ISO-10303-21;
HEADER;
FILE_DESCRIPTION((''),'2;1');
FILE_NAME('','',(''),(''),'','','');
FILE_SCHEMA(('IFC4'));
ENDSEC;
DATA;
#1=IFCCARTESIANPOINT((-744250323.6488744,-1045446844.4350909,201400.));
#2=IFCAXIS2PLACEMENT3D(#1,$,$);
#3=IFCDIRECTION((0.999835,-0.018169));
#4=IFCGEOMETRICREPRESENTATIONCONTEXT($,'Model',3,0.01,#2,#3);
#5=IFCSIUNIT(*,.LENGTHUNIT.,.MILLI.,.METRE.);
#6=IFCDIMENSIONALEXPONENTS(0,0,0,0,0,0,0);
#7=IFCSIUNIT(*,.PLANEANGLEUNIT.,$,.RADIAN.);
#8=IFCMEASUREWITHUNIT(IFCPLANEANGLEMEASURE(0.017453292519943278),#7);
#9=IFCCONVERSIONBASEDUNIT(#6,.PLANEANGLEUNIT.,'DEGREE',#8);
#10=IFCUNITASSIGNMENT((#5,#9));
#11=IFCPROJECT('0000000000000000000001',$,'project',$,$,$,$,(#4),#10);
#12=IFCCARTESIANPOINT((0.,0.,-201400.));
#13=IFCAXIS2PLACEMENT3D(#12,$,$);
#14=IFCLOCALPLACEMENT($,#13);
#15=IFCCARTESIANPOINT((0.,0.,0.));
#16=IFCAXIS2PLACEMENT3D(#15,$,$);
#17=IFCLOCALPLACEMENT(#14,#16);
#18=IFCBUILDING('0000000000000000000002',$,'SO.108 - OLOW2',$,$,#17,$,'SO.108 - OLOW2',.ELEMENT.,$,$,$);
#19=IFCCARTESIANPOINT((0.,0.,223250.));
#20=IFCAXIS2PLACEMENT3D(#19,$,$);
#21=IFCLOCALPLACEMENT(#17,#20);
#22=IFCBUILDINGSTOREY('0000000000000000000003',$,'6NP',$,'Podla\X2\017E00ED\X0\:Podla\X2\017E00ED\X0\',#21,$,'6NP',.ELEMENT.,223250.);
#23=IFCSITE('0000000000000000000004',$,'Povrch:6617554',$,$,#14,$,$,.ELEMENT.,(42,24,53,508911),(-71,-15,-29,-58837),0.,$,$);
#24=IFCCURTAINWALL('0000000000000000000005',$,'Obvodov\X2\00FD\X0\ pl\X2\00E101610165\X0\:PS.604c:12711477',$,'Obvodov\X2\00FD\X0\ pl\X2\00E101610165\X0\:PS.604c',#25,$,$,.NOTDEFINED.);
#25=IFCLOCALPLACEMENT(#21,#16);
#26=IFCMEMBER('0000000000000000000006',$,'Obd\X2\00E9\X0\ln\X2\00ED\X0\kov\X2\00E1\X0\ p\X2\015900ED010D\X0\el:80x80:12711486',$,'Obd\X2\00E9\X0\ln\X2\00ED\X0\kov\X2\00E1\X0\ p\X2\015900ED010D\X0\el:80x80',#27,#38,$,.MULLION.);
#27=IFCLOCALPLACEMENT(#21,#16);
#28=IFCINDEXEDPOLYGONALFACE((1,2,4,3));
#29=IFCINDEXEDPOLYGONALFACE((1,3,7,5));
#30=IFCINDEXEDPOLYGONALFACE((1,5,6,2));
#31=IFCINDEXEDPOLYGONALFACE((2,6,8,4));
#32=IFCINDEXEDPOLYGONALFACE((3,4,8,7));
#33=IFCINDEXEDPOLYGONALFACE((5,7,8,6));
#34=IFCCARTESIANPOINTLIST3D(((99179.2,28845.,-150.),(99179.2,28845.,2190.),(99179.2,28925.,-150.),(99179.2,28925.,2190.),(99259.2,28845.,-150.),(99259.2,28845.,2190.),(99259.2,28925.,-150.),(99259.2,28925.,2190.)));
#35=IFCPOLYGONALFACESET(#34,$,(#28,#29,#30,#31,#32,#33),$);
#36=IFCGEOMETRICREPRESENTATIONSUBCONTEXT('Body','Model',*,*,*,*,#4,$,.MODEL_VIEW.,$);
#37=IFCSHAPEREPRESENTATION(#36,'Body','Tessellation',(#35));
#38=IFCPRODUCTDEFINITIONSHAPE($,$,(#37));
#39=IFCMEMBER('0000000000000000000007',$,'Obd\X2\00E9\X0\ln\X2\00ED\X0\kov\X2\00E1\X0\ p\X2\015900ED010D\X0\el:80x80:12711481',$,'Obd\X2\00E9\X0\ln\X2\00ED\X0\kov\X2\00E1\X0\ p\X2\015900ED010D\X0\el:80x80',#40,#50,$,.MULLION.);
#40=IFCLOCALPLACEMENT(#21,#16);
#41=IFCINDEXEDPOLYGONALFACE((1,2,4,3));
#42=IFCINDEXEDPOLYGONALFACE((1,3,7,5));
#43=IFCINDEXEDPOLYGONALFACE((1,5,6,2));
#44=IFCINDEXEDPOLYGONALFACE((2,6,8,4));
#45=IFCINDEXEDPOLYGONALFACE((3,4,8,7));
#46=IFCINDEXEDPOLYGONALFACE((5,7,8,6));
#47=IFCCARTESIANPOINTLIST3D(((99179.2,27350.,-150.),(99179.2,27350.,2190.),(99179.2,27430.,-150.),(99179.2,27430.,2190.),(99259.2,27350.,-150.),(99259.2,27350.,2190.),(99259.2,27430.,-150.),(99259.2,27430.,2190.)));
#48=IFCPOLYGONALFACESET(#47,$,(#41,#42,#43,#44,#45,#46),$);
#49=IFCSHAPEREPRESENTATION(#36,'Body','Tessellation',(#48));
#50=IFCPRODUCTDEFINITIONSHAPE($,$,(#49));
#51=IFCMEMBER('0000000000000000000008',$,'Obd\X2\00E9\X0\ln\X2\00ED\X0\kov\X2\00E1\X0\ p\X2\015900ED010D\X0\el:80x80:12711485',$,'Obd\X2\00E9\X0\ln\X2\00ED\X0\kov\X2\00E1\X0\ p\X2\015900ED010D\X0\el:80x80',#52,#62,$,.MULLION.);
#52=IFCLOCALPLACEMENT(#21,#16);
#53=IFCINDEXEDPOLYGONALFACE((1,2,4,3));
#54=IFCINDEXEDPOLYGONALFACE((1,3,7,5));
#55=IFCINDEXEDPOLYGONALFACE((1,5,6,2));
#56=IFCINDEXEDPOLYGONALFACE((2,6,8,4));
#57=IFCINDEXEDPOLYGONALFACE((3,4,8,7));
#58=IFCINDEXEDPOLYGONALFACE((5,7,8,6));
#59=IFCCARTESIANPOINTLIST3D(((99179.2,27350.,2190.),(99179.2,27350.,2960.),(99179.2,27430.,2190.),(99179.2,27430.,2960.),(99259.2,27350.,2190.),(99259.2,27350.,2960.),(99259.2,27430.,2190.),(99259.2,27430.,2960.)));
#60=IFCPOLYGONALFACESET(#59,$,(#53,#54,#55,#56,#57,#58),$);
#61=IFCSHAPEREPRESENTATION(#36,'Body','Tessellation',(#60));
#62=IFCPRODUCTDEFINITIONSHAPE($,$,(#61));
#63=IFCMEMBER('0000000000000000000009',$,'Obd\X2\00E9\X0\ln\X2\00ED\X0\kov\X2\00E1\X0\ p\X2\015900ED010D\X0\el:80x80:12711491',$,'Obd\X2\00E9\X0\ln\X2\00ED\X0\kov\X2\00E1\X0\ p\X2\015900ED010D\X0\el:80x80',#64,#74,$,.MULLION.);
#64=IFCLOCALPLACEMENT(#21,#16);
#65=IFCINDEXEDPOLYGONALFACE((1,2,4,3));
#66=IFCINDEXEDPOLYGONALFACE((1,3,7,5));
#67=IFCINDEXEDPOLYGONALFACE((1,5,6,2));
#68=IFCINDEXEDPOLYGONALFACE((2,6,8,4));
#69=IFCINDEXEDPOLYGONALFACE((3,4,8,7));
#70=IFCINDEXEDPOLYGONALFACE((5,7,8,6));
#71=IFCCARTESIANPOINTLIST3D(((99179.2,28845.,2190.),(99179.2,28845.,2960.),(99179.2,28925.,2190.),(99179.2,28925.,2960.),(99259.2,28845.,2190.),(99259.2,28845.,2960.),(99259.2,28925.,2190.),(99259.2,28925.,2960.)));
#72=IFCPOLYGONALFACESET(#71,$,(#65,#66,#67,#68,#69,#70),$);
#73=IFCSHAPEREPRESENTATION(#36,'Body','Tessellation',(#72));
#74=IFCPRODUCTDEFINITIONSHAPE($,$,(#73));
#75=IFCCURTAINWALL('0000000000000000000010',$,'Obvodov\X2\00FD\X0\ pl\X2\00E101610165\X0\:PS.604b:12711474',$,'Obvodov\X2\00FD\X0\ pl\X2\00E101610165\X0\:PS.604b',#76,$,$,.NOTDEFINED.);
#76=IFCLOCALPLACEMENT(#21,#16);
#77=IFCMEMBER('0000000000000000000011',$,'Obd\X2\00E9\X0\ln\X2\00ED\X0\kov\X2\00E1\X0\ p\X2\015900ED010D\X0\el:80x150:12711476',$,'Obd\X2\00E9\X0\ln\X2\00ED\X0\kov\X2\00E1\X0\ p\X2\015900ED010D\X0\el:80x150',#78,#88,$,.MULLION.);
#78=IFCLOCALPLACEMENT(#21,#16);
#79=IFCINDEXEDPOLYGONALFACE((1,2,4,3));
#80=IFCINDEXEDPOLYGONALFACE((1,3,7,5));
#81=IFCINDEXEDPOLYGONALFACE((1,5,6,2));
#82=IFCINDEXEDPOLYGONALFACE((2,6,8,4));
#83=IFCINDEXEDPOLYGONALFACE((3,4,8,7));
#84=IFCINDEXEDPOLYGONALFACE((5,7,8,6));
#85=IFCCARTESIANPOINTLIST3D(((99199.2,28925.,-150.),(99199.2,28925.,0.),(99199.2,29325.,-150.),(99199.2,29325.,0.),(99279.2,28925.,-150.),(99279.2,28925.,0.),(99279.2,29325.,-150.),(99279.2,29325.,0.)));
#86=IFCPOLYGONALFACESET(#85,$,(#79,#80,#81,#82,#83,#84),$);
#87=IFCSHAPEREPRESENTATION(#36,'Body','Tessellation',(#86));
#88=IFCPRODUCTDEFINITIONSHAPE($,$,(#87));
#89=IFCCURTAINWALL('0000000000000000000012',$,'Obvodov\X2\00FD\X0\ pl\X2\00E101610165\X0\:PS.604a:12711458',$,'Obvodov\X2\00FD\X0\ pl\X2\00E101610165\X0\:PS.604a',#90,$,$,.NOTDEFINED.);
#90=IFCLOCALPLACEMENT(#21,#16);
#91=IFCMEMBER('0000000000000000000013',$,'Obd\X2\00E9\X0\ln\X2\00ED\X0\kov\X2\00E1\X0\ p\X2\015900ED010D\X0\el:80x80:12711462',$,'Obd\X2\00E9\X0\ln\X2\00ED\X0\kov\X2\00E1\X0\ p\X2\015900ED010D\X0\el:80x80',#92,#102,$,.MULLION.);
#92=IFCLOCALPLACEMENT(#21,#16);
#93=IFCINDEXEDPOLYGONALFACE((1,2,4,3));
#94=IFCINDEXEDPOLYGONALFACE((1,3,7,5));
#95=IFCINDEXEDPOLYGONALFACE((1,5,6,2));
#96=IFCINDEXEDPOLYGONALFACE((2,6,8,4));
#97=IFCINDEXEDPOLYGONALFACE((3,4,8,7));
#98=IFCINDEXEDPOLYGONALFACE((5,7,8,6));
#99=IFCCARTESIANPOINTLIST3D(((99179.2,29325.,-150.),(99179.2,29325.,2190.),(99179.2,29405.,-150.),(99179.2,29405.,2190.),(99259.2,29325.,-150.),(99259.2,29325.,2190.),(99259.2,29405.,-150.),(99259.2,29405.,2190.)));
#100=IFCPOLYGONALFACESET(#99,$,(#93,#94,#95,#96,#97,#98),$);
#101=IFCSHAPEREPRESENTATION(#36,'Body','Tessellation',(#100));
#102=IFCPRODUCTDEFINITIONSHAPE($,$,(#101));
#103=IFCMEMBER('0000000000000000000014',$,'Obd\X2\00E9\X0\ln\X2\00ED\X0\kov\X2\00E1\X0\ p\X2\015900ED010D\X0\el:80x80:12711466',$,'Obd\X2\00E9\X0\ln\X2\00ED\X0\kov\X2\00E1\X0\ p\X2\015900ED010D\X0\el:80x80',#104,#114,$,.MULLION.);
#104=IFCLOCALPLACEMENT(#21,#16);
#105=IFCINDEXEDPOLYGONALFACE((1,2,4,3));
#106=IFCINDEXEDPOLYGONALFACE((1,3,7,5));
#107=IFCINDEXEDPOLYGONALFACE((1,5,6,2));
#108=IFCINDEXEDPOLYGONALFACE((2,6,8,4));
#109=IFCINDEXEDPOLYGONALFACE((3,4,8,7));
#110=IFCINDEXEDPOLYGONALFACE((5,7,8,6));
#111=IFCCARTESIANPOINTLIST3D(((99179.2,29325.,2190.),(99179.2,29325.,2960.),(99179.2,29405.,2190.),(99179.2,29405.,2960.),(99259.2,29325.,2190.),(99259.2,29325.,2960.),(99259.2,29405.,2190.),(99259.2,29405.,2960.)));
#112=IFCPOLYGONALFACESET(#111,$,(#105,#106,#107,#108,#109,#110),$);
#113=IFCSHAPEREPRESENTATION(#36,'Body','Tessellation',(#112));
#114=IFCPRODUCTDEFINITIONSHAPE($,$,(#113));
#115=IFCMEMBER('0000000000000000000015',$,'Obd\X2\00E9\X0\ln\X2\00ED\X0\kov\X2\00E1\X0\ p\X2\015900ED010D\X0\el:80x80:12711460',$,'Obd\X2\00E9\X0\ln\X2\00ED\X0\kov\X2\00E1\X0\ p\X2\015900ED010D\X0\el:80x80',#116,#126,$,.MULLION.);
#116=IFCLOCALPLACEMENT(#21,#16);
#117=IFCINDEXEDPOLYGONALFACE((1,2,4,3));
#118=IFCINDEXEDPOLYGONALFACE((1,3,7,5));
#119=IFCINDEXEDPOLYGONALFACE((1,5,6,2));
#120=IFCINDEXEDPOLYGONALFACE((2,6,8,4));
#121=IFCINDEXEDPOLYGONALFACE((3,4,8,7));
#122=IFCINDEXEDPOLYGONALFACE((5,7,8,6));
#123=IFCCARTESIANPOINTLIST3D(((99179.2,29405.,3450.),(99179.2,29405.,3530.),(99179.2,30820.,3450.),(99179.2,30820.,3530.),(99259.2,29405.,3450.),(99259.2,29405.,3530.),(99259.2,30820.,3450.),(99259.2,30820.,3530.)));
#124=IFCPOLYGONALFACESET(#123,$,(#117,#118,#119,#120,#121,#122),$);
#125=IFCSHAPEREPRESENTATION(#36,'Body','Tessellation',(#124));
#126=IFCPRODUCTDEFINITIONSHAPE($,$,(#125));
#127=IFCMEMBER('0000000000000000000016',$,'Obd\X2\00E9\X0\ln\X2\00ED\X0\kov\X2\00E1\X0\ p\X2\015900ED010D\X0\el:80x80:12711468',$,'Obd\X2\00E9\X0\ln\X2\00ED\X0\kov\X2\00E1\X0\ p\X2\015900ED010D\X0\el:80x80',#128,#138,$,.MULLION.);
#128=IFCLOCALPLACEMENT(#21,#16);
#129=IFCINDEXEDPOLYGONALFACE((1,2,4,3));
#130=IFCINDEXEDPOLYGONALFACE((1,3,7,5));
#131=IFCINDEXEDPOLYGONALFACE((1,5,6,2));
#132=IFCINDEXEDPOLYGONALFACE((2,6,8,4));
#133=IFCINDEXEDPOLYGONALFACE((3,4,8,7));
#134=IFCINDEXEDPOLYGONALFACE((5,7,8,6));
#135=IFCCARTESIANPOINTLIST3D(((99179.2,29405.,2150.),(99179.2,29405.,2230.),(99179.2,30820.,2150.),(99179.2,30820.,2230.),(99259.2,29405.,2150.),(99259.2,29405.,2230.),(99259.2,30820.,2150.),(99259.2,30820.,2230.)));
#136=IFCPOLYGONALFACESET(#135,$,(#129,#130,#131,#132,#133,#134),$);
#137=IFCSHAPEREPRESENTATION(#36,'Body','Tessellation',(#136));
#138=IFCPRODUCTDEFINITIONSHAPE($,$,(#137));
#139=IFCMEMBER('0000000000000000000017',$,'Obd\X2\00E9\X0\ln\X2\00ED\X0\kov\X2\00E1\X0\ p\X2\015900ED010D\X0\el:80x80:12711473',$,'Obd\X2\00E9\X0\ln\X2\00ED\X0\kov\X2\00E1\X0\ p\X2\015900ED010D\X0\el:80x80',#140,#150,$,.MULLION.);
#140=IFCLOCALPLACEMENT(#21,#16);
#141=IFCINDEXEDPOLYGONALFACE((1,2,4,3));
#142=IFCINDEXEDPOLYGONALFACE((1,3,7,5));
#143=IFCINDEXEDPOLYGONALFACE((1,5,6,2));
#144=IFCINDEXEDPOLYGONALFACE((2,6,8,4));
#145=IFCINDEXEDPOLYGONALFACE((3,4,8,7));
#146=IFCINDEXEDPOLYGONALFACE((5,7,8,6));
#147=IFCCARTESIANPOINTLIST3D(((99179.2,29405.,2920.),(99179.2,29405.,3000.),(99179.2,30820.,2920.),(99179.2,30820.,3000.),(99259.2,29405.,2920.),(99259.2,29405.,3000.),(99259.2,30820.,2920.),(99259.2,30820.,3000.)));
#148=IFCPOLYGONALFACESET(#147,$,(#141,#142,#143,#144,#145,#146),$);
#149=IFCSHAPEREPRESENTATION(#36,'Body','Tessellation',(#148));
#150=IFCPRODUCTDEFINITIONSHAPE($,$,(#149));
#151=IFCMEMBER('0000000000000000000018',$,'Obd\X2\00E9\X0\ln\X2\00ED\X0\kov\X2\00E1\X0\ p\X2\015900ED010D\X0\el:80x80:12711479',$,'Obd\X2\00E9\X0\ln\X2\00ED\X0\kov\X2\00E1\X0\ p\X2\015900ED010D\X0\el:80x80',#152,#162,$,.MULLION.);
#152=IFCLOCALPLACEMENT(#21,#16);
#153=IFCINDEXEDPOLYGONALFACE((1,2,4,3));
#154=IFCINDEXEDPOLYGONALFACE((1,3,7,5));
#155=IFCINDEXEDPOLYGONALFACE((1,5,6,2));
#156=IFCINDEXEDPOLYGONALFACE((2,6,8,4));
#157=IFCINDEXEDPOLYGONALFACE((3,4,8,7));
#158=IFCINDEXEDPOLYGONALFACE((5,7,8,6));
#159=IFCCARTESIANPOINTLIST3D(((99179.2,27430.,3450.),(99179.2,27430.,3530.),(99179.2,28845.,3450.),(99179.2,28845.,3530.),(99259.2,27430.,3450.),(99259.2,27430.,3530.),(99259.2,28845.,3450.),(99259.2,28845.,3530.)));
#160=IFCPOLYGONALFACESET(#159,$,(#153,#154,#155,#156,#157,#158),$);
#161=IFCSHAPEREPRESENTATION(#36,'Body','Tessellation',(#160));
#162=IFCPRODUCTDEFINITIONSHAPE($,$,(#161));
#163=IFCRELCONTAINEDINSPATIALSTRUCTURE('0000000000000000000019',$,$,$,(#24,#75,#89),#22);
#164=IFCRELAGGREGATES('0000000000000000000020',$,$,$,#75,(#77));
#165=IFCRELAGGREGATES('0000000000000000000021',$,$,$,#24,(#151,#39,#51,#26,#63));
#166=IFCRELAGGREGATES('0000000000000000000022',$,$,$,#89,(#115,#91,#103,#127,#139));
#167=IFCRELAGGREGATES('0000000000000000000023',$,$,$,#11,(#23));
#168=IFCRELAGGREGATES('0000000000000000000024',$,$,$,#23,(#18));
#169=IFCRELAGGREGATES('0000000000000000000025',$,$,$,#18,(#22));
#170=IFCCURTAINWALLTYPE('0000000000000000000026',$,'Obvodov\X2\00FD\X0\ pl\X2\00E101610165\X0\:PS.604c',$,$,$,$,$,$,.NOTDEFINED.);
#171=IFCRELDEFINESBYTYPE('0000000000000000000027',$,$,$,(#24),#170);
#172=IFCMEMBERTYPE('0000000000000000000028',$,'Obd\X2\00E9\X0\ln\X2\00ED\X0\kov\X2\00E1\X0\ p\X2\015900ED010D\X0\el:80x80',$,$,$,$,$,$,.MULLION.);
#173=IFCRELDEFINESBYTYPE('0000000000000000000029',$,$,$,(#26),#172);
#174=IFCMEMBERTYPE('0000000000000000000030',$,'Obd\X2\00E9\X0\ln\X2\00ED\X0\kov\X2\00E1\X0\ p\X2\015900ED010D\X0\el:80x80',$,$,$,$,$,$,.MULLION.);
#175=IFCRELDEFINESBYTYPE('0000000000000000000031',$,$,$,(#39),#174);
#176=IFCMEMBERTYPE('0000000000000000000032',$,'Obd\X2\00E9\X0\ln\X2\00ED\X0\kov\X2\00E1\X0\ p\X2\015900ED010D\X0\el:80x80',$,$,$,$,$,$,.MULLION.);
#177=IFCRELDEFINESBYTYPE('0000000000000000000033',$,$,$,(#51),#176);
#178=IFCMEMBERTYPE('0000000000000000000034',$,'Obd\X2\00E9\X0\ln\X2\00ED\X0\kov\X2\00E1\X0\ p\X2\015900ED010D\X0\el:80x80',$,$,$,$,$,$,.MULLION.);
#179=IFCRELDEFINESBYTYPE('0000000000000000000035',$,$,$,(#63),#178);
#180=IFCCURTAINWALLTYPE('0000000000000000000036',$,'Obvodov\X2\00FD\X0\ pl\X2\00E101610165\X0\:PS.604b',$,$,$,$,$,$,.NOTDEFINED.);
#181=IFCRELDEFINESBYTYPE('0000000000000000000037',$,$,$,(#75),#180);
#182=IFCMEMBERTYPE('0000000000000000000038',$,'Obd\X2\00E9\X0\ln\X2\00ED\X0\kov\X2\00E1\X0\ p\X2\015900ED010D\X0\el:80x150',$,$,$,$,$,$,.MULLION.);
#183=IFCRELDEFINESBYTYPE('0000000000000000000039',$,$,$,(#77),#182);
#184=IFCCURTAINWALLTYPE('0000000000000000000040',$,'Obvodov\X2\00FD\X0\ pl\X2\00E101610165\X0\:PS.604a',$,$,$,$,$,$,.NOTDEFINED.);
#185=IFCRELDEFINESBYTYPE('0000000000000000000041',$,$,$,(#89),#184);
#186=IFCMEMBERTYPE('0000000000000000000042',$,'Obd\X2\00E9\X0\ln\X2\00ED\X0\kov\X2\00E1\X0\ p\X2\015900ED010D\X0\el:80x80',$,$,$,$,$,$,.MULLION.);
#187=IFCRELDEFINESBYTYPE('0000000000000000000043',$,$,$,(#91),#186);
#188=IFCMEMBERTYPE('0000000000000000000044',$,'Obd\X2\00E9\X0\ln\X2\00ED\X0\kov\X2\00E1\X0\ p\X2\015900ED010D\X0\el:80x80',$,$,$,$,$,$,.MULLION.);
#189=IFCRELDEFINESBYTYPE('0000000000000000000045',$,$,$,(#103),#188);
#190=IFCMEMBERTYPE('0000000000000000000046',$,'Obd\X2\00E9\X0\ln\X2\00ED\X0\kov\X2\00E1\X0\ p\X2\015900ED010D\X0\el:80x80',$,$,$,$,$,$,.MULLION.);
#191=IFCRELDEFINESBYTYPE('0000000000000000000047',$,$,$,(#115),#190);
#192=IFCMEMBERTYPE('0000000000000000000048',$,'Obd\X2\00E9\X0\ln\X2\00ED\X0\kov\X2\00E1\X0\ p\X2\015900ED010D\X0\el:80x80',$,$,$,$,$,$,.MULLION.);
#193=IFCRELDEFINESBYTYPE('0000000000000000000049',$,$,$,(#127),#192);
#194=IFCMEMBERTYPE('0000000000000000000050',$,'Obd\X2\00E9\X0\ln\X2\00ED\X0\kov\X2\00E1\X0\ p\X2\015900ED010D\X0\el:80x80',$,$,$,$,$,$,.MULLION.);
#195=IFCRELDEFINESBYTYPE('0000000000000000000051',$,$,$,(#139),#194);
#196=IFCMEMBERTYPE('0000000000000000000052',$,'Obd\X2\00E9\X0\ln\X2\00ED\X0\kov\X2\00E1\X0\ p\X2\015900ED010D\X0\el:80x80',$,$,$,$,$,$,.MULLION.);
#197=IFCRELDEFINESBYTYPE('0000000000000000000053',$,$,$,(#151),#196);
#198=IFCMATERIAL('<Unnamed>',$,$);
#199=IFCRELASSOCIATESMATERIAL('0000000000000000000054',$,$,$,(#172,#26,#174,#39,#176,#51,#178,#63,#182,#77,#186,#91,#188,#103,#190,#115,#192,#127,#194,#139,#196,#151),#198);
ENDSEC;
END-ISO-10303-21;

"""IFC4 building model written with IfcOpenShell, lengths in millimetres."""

from ifc_helpers import new_model, entity, si_unit, converted_unit, direction, frame, origin, place, context, subcontext, project, spatial, indexed_curve, outline, extrude, source, transform, mapped, material, type_object, type_shapes, element, aggregate, save


model = new_model("IFC4")

# Units and contexts
model_context = context("Model", 3, precision=0.01, world=frame((-744250323.6488744, -1045446844.4350909, 201400.0)), true_north=direction((0.999835, -0.018169)))
body_context = subcontext(model_context, "Body", "Model", "MODEL_VIEW")
ifc_project = project(units=[si_unit("LENGTHUNIT", "METRE", prefix="MILLI"), converted_unit("PLANEANGLEUNIT", "DEGREE", entity("IfcPlaneAngleMeasure", 0.017453292519943278), si_unit("PLANEANGLEUNIT", "RADIAN"), dimensions=[0, 0, 0, 0, 0, 0, 0])], contexts=[model_context])

# Site, building, storey
site_placement = place(None, frame((0.0, 0.0, -201400.0)))
site = spatial("IfcSite", under=ifc_project, at=site_placement, Name="Povrch:6617554", CompositionType="ELEMENT", RefLatitude=(42, 24, 53, 508911), RefLongitude=(-71, -15, -29, -58837), RefElevation=0.0)
building_placement = place(site_placement, origin())
building = spatial("IfcBuilding", under=site, at=building_placement, Name="SO.108 - OLOW2", LongName="SO.108 - OLOW2", CompositionType="ELEMENT")
storey_placement = place(building_placement, frame((0.0, 0.0, 223250.0)))
storey = spatial("IfcBuildingStorey", under=building, at=storey_placement, Name="6NP", ObjectType="Podlaží:Podlaží", LongName="6NP", CompositionType="ELEMENT", Elevation=223250.0)

# Curtain wall, members
curtain_wall_type_1 = type_object("IfcCurtainWallType", Name="Obvodový plášť:PS.604c", PredefinedType="NOTDEFINED")
curtain_wall_1_placement = place(storey_placement, frame((0.0, 0.0, -223250.0)))
curtain_wall_1 = element("IfcCurtainWall", 1, at=curtain_wall_1_placement, inside=storey, type_object=curtain_wall_type_1, Name="Obvodový plášť:PS.604c:12711477", ObjectType="Obvodový plášť:PS.604c", PredefinedType="NOTDEFINED")
ifc_material_1 = material(Name="<Unnamed>")
member_type_1 = type_object("IfcMemberType", Name="Obdélníková příčel:80x80", PredefinedType="MULLION", material=ifc_material_1)
shared_shape_1 = source(origin(), body_context, "Body", "SweptSolid", [
    extrude(outline(indexed_curve([(-40.0, -40.0), (40.0, -40.0), (40.0, 40.0), (-40.0, 40.0), (-40.0, -40.0)], self_intersect=False)), frame((-40.0, 0.0, -2340.0), z_axis=(0.0, 0.0, 1.0), x_axis=(-1.0, 0.0, 0.0)), (0.0, 0.0, 1.0), 2340.0),
])
type_shapes(member_type_1, [shared_shape_1])
member_1_placement = place(curtain_wall_1_placement, frame((99219.2, 28925.0, 225440.0), z_axis=(0.0, 0.0, 1.0), x_axis=(0.0, 1.0, 0.0)))
member_1 = element("IfcMember", 2, at=member_1_placement, type_object=member_type_1, material=ifc_material_1, Name="Obdélníková příčel:80x80:12711486", ObjectType="Obdélníková příčel:80x80", PredefinedType="MULLION", context=body_context, shape_type="MappedRepresentation", body=[
    mapped(shared_shape_1, transform((0.0, 0.0, 0.0), scale=1.0)),
])
member_type_2 = type_object("IfcMemberType", Name="Obdélníková příčel:80x80", PredefinedType="MULLION", material=ifc_material_1)
shared_shape_2 = source(origin(), body_context, "Body", "SweptSolid", [
    extrude(outline(indexed_curve([(-40.0, -40.0), (40.0, -40.0), (40.0, 40.0), (-40.0, 40.0), (-40.0, -40.0)], self_intersect=False)), frame((-40.0, 0.0, -2340.0), z_axis=(0.0, 0.0, 1.0), x_axis=(-1.0, 0.0, 0.0)), (0.0, 0.0, 1.0), 2340.0),
])
type_shapes(member_type_2, [shared_shape_2])
member_2_placement = place(curtain_wall_1_placement, frame((99219.2, 27350.0, 223100.0), z_axis=(0.0, 0.0, -1.0), x_axis=(0.0, -1.0, 0.0)))
member_2 = element("IfcMember", 3, at=member_2_placement, type_object=member_type_2, material=ifc_material_1, Name="Obdélníková příčel:80x80:12711481", ObjectType="Obdélníková příčel:80x80", PredefinedType="MULLION", context=body_context, shape_type="MappedRepresentation", body=[
    mapped(shared_shape_2, transform((0.0, 0.0, 0.0), scale=1.0)),
])
member_type_3 = type_object("IfcMemberType", Name="Obdélníková příčel:80x80", PredefinedType="MULLION", material=ifc_material_1)
shared_shape_3 = source(origin(), body_context, "Body", "SweptSolid", [
    extrude(outline(indexed_curve([(-40.0, -40.0), (40.0, -40.0), (40.0, 40.0), (-40.0, 40.0), (-40.0, -40.0)], self_intersect=False)), frame((-40.0, 0.0, -770.0), z_axis=(0.0, 0.0, 1.0), x_axis=(-1.0, 0.0, 0.0)), (0.0, 0.0, 1.0), 770.0),
])
type_shapes(member_type_3, [shared_shape_3])
member_3_placement = place(curtain_wall_1_placement, frame((99219.2, 27350.0, 225440.0), z_axis=(0.0, 0.0, -1.0), x_axis=(0.0, -1.0, 0.0)))
member_3 = element("IfcMember", 4, at=member_3_placement, type_object=member_type_3, material=ifc_material_1, Name="Obdélníková příčel:80x80:12711485", ObjectType="Obdélníková příčel:80x80", PredefinedType="MULLION", context=body_context, shape_type="MappedRepresentation", body=[
    mapped(shared_shape_3, transform((0.0, 0.0, 0.0), scale=1.0)),
])
member_type_4 = type_object("IfcMemberType", Name="Obdélníková příčel:80x80", PredefinedType="MULLION", material=ifc_material_1)
shared_shape_4 = source(origin(), body_context, "Body", "SweptSolid", [
    extrude(outline(indexed_curve([(-40.0, -40.0), (40.0, -40.0), (40.0, 40.0), (-40.0, 40.0), (-40.0, -40.0)], self_intersect=False)), frame((-40.0, 0.0, -770.0), z_axis=(0.0, 0.0, 1.0), x_axis=(-1.0, 0.0, 0.0)), (0.0, 0.0, 1.0), 770.0),
])
type_shapes(member_type_4, [shared_shape_4])
member_4_placement = place(curtain_wall_1_placement, frame((99219.2, 28925.0, 226210.0), z_axis=(0.0, 0.0, 1.0), x_axis=(0.0, 1.0, 0.0)))
member_4 = element("IfcMember", 5, at=member_4_placement, type_object=member_type_4, material=ifc_material_1, Name="Obdélníková příčel:80x80:12711491", ObjectType="Obdélníková příčel:80x80", PredefinedType="MULLION", context=body_context, shape_type="MappedRepresentation", body=[
    mapped(shared_shape_4, transform((0.0, 0.0, 0.0), scale=1.0)),
])

# Curtain wall, member
curtain_wall_type_2 = type_object("IfcCurtainWallType", Name="Obvodový plášť:PS.604b", PredefinedType="NOTDEFINED")
curtain_wall_2_placement = place(storey_placement, frame((0.0, 0.0, -223250.0)))
curtain_wall_2 = element("IfcCurtainWall", 6, at=curtain_wall_2_placement, inside=storey, type_object=curtain_wall_type_2, Name="Obvodový plášť:PS.604b:12711474", ObjectType="Obvodový plášť:PS.604b", PredefinedType="NOTDEFINED")
member_type_5 = type_object("IfcMemberType", Name="Obdélníková příčel:80x150", PredefinedType="MULLION", material=ifc_material_1)
shared_shape_5 = source(origin(), body_context, "Body", "SweptSolid", [
    extrude(outline(indexed_curve([(-75.0, -40.0), (75.0, -40.0), (75.0, 40.0), (-75.0, 40.0), (-75.0, -40.0)], self_intersect=False)), frame((-75.0, 0.0, -400.0), z_axis=(0.0, 0.0, 1.0), x_axis=(-1.0, 0.0, 0.0)), (0.0, 0.0, 1.0), 400.0),
])
type_shapes(member_type_5, [shared_shape_5])
member_5_placement = place(curtain_wall_2_placement, frame((99239.2, 28925.0, 223100.0), z_axis=(0.0, -1.0, 0.0), x_axis=(0.0, 0.0, -1.0)))
member_5 = element("IfcMember", 7, at=member_5_placement, type_object=member_type_5, material=ifc_material_1, Name="Obdélníková příčel:80x150:12711476", ObjectType="Obdélníková příčel:80x150", PredefinedType="MULLION", context=body_context, shape_type="MappedRepresentation", body=[
    mapped(shared_shape_5, transform((0.0, 0.0, 0.0), scale=1.0)),
])

# Curtain wall, members
curtain_wall_type_3 = type_object("IfcCurtainWallType", Name="Obvodový plášť:PS.604a", PredefinedType="NOTDEFINED")
curtain_wall_3_placement = place(storey_placement, frame((0.0, 0.0, -223250.0)))
curtain_wall_3 = element("IfcCurtainWall", 8, at=curtain_wall_3_placement, inside=storey, type_object=curtain_wall_type_3, Name="Obvodový plášť:PS.604a:12711458", ObjectType="Obvodový plášť:PS.604a", PredefinedType="NOTDEFINED")
member_type_6 = type_object("IfcMemberType", Name="Obdélníková příčel:80x80", PredefinedType="MULLION", material=ifc_material_1)
shared_shape_6 = source(origin(), body_context, "Body", "SweptSolid", [
    extrude(outline(indexed_curve([(-40.0, -40.0), (40.0, -40.0), (40.0, 40.0), (-40.0, 40.0), (-40.0, -40.0)], self_intersect=False)), frame((-40.0, 0.0, -2340.0), z_axis=(0.0, 0.0, 1.0), x_axis=(-1.0, 0.0, 0.0)), (0.0, 0.0, 1.0), 2340.0),
])
type_shapes(member_type_6, [shared_shape_6])
member_6_placement = place(curtain_wall_3_placement, frame((99219.2, 29325.0, 223100.0), z_axis=(0.0, 0.0, -1.0), x_axis=(0.0, -1.0, 0.0)))
member_6 = element("IfcMember", 9, at=member_6_placement, type_object=member_type_6, material=ifc_material_1, Name="Obdélníková příčel:80x80:12711462", ObjectType="Obdélníková příčel:80x80", PredefinedType="MULLION", context=body_context, shape_type="MappedRepresentation", body=[
    mapped(shared_shape_6, transform((0.0, 0.0, 0.0), scale=1.0)),
])
member_type_7 = type_object("IfcMemberType", Name="Obdélníková příčel:80x80", PredefinedType="MULLION", material=ifc_material_1)
shared_shape_7 = source(origin(), body_context, "Body", "SweptSolid", [
    extrude(outline(indexed_curve([(-40.0, -40.0), (40.0, -40.0), (40.0, 40.0), (-40.0, 40.0), (-40.0, -40.0)], self_intersect=False)), frame((-40.0, 0.0, -770.0), z_axis=(0.0, 0.0, 1.0), x_axis=(-1.0, 0.0, 0.0)), (0.0, 0.0, 1.0), 770.0),
])
type_shapes(member_type_7, [shared_shape_7])
member_7_placement = place(curtain_wall_3_placement, frame((99219.2, 29325.0, 225440.0), z_axis=(0.0, 0.0, -1.0), x_axis=(0.0, -1.0, 0.0)))
member_7 = element("IfcMember", 10, at=member_7_placement, type_object=member_type_7, material=ifc_material_1, Name="Obdélníková příčel:80x80:12711466", ObjectType="Obdélníková příčel:80x80", PredefinedType="MULLION", context=body_context, shape_type="MappedRepresentation", body=[
    mapped(shared_shape_7, transform((0.0, 0.0, 0.0), scale=1.0)),
])
member_type_8 = type_object("IfcMemberType", Name="Obdélníková příčel:80x80", PredefinedType="MULLION", material=ifc_material_1)
shared_shape_8 = source(origin(), body_context, "Body", "SweptSolid", [
    extrude(outline(indexed_curve([(-40.0, -40.0), (40.0, -40.0), (40.0, 40.0), (-40.0, 40.0), (-40.0, -40.0)], self_intersect=False)), frame((-40.0, 0.0, -1415.0), z_axis=(0.0, 0.0, 1.0), x_axis=(-1.0, 0.0, 0.0)), (0.0, 0.0, 1.0), 1415.0),
])
type_shapes(member_type_8, [shared_shape_8])
member_8_placement = place(curtain_wall_3_placement, frame((99219.2, 29405.0, 226780.0), z_axis=(0.0, -1.0, 0.0), x_axis=(0.0, 0.0, 1.0)))
member_8 = element("IfcMember", 11, at=member_8_placement, type_object=member_type_8, material=ifc_material_1, Name="Obdélníková příčel:80x80:12711460", ObjectType="Obdélníková příčel:80x80", PredefinedType="MULLION", context=body_context, shape_type="MappedRepresentation", body=[
    mapped(shared_shape_8, transform((0.0, 0.0, 0.0), scale=1.0)),
])
member_type_9 = type_object("IfcMemberType", Name="Obdélníková příčel:80x80", PredefinedType="MULLION", material=ifc_material_1)
shared_shape_9 = source(origin(), body_context, "Body", "SweptSolid", [
    extrude(outline(indexed_curve([(-40.0, -40.0), (40.0, -40.0), (40.0, 40.0), (-40.0, 40.0), (-40.0, -40.0)], self_intersect=False)), frame((0.0, 0.0, -1415.0), z_axis=(0.0, 0.0, 1.0), x_axis=(-1.0, 0.0, 0.0)), (0.0, 0.0, 1.0), 1415.0),
])
type_shapes(member_type_9, [shared_shape_9])
member_9_placement = place(curtain_wall_3_placement, frame((99219.2, 29405.0, 225440.0), z_axis=(0.0, -1.0, 0.0), x_axis=(0.0, 0.0, 1.0)))
member_9 = element("IfcMember", 12, at=member_9_placement, type_object=member_type_9, material=ifc_material_1, Name="Obdélníková příčel:80x80:12711468", ObjectType="Obdélníková příčel:80x80", PredefinedType="MULLION", context=body_context, shape_type="MappedRepresentation", body=[
    mapped(shared_shape_9, transform((0.0, 0.0, 0.0), scale=1.0)),
])
member_type_10 = type_object("IfcMemberType", Name="Obdélníková příčel:80x80", PredefinedType="MULLION", material=ifc_material_1)
shared_shape_10 = source(origin(), body_context, "Body", "SweptSolid", [
    extrude(outline(indexed_curve([(-40.0, -40.0), (40.0, -40.0), (40.0, 40.0), (-40.0, 40.0), (-40.0, -40.0)], self_intersect=False)), frame((0.0, 0.0, -1415.0), z_axis=(0.0, 0.0, 1.0), x_axis=(-1.0, 0.0, 0.0)), (0.0, 0.0, 1.0), 1415.0),
])
type_shapes(member_type_10, [shared_shape_10])
member_10_placement = place(curtain_wall_3_placement, frame((99219.2, 29405.0, 226210.0), z_axis=(0.0, -1.0, 0.0), x_axis=(0.0, 0.0, 1.0)))
member_10 = element("IfcMember", 13, at=member_10_placement, type_object=member_type_10, material=ifc_material_1, Name="Obdélníková příčel:80x80:12711473", ObjectType="Obdélníková příčel:80x80", PredefinedType="MULLION", context=body_context, shape_type="MappedRepresentation", body=[
    mapped(shared_shape_10, transform((0.0, 0.0, 0.0), scale=1.0)),
])

# Member
member_type_11 = type_object("IfcMemberType", Name="Obdélníková příčel:80x80", PredefinedType="MULLION", material=ifc_material_1)
shared_shape_11 = source(origin(), body_context, "Body", "SweptSolid", [
    extrude(outline(indexed_curve([(-40.0, -40.0), (40.0, -40.0), (40.0, 40.0), (-40.0, 40.0), (-40.0, -40.0)], self_intersect=False)), frame((-40.0, 0.0, -1415.0), z_axis=(0.0, 0.0, 1.0), x_axis=(-1.0, 0.0, 0.0)), (0.0, 0.0, 1.0), 1415.0),
])
type_shapes(member_type_11, [shared_shape_11])
member_11_placement = place(curtain_wall_1_placement, frame((99219.2, 27430.0, 226780.0), z_axis=(0.0, -1.0, 0.0), x_axis=(0.0, 0.0, 1.0)))
member_11 = element("IfcMember", 14, at=member_11_placement, type_object=member_type_11, material=ifc_material_1, Name="Obdélníková příčel:80x80:12711479", ObjectType="Obdélníková příčel:80x80", PredefinedType="MULLION", context=body_context, shape_type="MappedRepresentation", body=[
    mapped(shared_shape_11, transform((0.0, 0.0, 0.0), scale=1.0)),
])

aggregate(curtain_wall_2, [member_5])
aggregate(curtain_wall_1, [member_11, member_2, member_3, member_1, member_4])

aggregate(curtain_wall_3, [member_8, member_6, member_7, member_9, member_10])

save(model, "model.ifc")
